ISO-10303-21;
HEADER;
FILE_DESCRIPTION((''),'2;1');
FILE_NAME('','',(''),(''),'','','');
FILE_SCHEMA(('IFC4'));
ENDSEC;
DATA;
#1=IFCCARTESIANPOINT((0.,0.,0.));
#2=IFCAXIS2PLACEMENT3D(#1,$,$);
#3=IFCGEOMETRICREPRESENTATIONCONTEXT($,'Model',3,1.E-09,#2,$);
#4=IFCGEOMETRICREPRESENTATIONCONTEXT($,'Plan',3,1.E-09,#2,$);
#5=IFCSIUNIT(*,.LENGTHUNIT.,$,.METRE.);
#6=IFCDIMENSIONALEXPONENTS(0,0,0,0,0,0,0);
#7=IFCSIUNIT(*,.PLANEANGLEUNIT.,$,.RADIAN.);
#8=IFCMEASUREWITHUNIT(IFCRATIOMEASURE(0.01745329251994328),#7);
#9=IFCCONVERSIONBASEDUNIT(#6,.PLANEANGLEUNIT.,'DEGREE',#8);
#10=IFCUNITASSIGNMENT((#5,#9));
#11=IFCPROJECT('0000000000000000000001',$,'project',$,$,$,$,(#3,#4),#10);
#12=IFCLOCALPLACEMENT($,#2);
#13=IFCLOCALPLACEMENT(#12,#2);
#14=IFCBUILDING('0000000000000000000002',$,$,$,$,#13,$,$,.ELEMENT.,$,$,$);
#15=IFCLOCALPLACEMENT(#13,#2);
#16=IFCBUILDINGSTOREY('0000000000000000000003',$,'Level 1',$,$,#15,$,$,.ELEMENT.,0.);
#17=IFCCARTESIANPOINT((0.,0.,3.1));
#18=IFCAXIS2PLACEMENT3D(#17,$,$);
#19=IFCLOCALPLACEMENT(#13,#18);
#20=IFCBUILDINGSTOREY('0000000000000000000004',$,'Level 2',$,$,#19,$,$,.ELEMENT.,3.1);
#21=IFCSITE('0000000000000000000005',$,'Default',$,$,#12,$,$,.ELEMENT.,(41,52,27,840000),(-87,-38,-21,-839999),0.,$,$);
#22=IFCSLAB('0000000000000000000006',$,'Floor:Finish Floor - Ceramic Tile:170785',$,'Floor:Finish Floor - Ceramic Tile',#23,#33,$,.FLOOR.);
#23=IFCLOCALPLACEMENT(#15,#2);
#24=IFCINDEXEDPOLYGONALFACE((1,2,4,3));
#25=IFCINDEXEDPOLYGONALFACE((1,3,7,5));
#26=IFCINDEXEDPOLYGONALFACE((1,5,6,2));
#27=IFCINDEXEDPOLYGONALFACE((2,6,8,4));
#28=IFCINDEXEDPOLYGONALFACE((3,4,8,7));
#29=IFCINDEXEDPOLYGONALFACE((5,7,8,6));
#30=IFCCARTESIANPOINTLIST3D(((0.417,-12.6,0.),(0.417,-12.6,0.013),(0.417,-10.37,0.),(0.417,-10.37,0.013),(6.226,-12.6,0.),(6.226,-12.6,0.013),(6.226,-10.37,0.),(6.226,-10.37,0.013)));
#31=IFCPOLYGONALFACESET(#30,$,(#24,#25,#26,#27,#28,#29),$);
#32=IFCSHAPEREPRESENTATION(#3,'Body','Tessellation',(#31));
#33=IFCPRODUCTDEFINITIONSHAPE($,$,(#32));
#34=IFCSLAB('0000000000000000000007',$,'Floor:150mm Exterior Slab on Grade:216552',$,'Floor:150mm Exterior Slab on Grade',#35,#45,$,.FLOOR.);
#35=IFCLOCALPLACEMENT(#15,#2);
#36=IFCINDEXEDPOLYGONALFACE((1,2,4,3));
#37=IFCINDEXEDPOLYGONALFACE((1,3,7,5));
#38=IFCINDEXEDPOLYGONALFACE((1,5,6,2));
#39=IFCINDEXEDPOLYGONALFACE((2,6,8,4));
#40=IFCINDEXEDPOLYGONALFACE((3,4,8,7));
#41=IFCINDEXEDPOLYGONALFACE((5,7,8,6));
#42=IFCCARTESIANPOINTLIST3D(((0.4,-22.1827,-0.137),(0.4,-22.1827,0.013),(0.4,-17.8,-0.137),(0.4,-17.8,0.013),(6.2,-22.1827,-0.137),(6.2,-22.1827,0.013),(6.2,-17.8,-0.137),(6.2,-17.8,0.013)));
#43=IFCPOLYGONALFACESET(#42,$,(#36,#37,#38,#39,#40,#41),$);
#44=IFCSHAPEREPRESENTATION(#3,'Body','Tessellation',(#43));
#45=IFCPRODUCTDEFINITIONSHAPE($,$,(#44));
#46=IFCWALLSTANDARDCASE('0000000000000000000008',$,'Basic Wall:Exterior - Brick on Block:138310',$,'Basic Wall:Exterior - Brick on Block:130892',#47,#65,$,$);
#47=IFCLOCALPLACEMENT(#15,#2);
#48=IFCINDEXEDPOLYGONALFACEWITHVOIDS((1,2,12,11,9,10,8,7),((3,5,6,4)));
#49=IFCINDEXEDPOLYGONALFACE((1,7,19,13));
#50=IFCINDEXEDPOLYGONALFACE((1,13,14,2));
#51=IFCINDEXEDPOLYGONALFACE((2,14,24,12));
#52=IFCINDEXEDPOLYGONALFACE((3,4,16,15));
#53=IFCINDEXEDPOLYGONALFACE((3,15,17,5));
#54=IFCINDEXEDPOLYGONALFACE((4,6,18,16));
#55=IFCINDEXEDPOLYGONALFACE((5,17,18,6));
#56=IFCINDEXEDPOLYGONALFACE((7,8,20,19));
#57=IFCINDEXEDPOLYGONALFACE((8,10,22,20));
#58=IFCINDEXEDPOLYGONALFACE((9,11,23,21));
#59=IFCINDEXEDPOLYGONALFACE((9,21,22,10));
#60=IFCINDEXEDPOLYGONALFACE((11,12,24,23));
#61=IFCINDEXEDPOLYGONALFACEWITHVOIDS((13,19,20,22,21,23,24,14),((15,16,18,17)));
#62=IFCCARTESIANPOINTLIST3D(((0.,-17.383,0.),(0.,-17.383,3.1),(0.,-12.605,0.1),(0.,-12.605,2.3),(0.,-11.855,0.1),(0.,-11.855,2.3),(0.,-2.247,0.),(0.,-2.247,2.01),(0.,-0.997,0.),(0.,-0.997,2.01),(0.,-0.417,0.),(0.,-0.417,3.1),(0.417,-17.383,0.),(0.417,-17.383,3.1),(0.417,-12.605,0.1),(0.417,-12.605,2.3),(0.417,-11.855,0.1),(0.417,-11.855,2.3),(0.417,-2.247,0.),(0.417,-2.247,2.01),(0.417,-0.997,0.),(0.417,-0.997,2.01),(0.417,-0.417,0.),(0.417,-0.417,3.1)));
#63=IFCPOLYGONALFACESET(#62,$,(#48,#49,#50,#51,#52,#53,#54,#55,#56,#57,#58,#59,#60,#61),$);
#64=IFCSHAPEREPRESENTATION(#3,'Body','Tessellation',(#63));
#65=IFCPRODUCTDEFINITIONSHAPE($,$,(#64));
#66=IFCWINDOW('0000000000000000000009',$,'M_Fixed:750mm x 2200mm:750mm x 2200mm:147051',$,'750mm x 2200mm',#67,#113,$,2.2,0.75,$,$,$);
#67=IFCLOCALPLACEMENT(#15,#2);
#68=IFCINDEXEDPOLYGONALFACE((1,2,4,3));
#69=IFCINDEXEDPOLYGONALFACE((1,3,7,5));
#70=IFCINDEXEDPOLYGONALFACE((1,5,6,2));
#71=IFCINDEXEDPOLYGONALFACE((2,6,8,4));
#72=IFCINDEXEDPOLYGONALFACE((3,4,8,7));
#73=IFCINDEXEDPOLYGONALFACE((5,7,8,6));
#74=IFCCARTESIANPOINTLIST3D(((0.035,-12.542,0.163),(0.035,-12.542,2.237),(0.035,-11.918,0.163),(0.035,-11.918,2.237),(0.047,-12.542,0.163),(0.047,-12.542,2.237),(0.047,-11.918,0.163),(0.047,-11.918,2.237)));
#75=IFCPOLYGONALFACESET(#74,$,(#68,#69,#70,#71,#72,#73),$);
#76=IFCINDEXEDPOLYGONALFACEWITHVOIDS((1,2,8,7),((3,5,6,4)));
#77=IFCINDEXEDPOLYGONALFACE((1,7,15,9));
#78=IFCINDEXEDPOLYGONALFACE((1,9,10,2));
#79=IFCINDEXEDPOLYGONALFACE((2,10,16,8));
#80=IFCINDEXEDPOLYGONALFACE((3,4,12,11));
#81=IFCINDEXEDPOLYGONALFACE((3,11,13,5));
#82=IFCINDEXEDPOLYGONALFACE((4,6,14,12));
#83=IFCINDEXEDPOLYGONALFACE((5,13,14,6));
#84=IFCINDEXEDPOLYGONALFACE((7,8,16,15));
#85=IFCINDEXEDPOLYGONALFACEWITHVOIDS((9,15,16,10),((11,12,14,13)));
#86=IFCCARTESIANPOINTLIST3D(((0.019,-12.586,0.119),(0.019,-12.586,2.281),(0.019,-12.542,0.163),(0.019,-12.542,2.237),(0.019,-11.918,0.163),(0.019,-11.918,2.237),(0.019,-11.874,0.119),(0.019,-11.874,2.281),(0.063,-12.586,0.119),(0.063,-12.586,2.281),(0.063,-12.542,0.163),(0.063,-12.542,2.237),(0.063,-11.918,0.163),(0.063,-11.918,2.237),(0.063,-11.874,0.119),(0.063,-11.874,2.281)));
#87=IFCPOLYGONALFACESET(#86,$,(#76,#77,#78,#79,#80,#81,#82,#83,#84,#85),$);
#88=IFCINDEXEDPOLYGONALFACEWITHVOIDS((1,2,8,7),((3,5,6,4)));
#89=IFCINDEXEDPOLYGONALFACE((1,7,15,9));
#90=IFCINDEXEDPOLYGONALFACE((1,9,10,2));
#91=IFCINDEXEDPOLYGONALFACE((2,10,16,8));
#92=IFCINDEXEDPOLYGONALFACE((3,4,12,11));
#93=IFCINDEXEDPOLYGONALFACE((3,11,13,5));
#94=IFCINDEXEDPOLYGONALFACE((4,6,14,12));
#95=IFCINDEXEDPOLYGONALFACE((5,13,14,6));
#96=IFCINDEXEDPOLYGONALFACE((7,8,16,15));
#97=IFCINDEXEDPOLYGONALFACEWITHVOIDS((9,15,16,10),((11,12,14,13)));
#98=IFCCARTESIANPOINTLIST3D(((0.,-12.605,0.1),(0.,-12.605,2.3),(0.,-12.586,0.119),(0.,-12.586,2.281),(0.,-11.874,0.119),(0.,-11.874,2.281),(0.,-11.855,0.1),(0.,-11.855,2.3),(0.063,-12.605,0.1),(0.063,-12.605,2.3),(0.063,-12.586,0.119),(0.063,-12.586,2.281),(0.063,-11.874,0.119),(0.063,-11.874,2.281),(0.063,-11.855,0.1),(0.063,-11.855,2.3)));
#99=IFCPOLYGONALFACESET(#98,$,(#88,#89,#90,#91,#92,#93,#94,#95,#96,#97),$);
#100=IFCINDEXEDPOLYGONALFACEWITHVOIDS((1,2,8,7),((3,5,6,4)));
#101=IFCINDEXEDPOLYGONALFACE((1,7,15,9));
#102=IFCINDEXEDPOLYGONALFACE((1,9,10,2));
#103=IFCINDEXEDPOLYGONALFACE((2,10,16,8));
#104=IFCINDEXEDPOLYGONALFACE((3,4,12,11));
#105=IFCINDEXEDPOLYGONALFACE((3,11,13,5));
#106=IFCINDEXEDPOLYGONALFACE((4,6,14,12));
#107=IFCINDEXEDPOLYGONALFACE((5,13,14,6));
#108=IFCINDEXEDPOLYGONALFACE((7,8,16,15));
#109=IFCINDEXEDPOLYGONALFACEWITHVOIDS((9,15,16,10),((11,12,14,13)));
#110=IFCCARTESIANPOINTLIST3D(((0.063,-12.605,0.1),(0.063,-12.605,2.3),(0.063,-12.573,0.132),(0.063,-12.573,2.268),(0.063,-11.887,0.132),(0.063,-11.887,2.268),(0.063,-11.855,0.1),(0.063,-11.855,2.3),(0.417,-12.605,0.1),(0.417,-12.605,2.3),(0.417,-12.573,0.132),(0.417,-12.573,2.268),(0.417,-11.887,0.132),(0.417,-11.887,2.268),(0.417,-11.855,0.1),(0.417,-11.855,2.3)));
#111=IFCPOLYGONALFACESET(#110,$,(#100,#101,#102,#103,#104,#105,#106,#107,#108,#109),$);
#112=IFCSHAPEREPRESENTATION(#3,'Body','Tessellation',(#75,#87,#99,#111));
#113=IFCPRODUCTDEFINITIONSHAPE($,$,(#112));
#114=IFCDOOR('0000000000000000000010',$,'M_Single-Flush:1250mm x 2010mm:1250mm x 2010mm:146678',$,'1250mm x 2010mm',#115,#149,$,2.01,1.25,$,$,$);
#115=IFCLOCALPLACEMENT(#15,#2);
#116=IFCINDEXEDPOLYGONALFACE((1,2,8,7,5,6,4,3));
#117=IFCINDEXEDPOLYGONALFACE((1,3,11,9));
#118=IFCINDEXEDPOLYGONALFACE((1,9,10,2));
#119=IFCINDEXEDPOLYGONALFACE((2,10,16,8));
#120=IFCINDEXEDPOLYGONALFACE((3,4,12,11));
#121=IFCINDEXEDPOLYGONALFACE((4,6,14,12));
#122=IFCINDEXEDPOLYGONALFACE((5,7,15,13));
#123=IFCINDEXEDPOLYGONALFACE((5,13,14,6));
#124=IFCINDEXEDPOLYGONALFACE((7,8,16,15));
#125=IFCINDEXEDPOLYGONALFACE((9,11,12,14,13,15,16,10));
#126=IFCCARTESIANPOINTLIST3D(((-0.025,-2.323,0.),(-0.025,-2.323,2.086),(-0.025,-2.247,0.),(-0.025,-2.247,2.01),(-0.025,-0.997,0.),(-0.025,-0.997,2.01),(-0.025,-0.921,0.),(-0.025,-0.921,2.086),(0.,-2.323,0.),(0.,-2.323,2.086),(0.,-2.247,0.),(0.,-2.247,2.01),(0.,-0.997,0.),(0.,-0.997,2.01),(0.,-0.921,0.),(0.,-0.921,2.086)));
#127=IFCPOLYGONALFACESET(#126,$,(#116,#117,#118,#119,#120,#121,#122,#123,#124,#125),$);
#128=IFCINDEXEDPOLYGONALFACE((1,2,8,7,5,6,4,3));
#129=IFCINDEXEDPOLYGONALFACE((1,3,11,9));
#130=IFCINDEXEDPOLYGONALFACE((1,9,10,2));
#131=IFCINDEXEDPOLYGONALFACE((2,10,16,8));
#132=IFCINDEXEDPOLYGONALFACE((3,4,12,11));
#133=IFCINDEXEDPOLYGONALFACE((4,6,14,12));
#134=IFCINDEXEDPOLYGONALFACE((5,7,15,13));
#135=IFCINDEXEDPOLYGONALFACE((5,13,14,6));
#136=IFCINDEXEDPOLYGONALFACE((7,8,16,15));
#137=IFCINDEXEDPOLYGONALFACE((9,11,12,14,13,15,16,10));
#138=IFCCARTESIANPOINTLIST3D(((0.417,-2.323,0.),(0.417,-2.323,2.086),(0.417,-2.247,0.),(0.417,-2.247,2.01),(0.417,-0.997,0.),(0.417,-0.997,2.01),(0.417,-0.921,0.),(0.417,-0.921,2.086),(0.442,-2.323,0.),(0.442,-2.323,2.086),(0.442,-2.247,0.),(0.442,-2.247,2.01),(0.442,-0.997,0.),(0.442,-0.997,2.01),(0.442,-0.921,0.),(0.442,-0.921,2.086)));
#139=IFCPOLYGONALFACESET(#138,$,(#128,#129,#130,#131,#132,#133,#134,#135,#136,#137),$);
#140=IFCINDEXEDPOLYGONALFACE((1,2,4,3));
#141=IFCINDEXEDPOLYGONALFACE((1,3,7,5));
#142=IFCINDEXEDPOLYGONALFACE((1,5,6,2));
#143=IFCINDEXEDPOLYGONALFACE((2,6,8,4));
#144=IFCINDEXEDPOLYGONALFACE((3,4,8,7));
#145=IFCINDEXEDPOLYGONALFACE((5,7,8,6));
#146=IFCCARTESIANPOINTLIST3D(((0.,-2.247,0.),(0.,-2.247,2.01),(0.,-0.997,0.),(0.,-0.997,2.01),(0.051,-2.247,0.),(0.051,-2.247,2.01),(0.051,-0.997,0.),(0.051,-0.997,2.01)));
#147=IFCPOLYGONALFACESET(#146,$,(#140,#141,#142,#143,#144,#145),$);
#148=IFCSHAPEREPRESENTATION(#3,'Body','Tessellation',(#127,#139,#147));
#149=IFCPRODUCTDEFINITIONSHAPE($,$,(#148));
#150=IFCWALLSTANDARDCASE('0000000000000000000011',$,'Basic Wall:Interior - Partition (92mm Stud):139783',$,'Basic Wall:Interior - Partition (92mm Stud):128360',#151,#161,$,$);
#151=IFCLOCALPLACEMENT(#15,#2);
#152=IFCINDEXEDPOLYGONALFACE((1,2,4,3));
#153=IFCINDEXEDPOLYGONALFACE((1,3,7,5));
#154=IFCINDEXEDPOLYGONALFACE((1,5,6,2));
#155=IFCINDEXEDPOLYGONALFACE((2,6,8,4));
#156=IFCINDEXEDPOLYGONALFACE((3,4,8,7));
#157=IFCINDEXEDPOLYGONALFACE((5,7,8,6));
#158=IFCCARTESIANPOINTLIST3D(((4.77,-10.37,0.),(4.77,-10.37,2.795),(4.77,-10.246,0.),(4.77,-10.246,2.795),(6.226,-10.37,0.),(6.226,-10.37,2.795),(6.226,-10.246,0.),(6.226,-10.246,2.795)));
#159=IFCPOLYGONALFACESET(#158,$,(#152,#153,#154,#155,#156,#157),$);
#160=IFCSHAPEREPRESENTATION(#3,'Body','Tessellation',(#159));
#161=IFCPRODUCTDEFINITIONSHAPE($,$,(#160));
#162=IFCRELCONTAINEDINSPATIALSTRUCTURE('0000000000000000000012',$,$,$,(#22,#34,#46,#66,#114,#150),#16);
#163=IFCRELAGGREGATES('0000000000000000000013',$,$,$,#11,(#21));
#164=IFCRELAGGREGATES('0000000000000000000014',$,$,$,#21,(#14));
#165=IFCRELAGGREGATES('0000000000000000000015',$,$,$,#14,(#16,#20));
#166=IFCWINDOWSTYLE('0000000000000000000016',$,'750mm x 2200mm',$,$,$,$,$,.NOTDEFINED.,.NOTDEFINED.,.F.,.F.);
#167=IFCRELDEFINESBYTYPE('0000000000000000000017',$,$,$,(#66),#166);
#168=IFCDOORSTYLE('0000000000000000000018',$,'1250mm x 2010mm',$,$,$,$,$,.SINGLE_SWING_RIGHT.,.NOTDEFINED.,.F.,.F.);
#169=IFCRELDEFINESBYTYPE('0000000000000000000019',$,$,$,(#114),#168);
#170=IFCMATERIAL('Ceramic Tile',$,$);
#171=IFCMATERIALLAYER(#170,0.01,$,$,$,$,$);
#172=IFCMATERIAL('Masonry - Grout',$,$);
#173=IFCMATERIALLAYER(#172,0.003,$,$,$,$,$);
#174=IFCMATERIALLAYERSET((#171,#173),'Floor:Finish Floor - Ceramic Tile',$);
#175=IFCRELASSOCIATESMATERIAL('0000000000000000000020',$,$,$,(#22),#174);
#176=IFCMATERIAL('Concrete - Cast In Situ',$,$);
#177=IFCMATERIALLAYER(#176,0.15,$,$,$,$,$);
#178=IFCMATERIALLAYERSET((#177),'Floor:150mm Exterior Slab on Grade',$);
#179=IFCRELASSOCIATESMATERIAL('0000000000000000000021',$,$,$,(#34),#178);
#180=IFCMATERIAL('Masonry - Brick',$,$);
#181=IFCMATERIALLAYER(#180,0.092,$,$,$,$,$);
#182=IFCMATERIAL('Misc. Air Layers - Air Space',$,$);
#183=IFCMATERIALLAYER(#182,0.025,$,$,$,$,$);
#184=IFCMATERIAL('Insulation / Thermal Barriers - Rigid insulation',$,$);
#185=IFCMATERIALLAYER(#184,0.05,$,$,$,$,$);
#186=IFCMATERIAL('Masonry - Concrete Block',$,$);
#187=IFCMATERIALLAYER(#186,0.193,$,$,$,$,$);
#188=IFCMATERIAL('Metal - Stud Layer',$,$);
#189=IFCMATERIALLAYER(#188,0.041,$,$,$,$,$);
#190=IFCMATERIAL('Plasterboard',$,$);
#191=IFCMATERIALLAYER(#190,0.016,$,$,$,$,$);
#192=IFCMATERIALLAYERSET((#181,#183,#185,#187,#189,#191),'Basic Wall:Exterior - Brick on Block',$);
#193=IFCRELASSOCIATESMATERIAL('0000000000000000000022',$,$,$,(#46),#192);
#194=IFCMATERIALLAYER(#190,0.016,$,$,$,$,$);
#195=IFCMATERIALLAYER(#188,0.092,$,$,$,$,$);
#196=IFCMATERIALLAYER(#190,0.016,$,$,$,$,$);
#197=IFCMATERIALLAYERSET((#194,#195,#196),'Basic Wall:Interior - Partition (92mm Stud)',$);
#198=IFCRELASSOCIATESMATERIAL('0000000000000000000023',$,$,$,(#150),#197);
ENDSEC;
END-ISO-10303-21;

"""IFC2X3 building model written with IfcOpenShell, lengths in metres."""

from ifc_helpers import new_model, entity, si_unit, converted_unit, frame, frame_2d, origin, origin_2d_with_axis, place, context, project, spatial, polyline, rectangle, outline, extrude, source, transform, mapped, material, layer, layer_set, layer_usage, type_object, type_shapes, element, fill, save


model = new_model("IFC2X3")

# Units and contexts
model_context = context("Model", 3, precision=1e-09, world=origin())
plan_context = context("Plan", 3, precision=1e-09, world=origin())
ifc_project = project(units=[si_unit("LENGTHUNIT", "METRE"), converted_unit("PLANEANGLEUNIT", "DEGREE", entity("IfcRatioMeasure", 0.01745329251994328), si_unit("PLANEANGLEUNIT", "RADIAN"), dimensions=[0, 0, 0, 0, 0, 0, 0])], contexts=[model_context, plan_context])

# Site, building, storey
site_placement = place(None, origin())
site = spatial("IfcSite", under=ifc_project, at=site_placement, Name="Default", CompositionType="ELEMENT", RefLatitude=(41, 52, 27, 840000), RefLongitude=(-87, -38, -21, -839999), RefElevation=0.0)
building_placement = place(site_placement, origin())
building = spatial("IfcBuilding", under=site, at=building_placement, CompositionType="ELEMENT")
storey_1_placement = place(building_placement, origin())
storey_1 = spatial("IfcBuildingStorey", under=building, at=storey_1_placement, Name="Level 1", CompositionType="ELEMENT", Elevation=0.0)

# Slabs
ifc_material_1 = material(Name="Ceramic Tile")
ifc_layer_1 = layer(ifc_material_1, 0.01)
ifc_material_2 = material(Name="Masonry - Grout")
ifc_layer_2 = layer(ifc_material_2, 0.003)
ifc_layer_set_1 = layer_set([ifc_layer_1, ifc_layer_2], Name="Floor:Finish Floor - Ceramic Tile")
ifc_layer_usage_1 = layer_usage(ifc_layer_set_1, "AXIS3", "POSITIVE", 0.0)
slab_1_placement = place(storey_1_placement, frame((0.417, -12.6, 0.0)))
element("IfcSlab", 1, at=slab_1_placement, inside=storey_1, material=ifc_layer_usage_1, Name="Floor:Finish Floor - Ceramic Tile:170785", ObjectType="Floor:Finish Floor - Ceramic Tile", PredefinedType="FLOOR", context=model_context, shape_type="SweptSolid", body=[
    extrude(rectangle(XDim=5.809, YDim=2.23, at=frame_2d((0.0, 0.0), x_axis=(-1.0, 0.0))), frame((2.9045, 1.115, 0.013), z_axis=(0.0, 0.0, -1.0), x_axis=(-1.0, 0.0, 0.0)), (0.0, 0.0, 1.0), 0.013),
])
ifc_material_3 = material(Name="Concrete - Cast In Situ")
ifc_layer_3 = layer(ifc_material_3, 0.15)
ifc_layer_set_2 = layer_set([ifc_layer_3], Name="Floor:150mm Exterior Slab on Grade")
ifc_layer_usage_2 = layer_usage(ifc_layer_set_2, "AXIS3", "POSITIVE", 0.0)
slab_2_placement = place(storey_1_placement, frame((0.4, -22.1827, -0.137)))
element("IfcSlab", 2, at=slab_2_placement, inside=storey_1, material=ifc_layer_usage_2, Name="Floor:150mm Exterior Slab on Grade:216552", ObjectType="Floor:150mm Exterior Slab on Grade", PredefinedType="FLOOR", context=model_context, shape_type="SweptSolid", body=[
    extrude(rectangle(XDim=5.8, YDim=4.3827, at=origin_2d_with_axis()), frame((2.9, 2.1914, 0.15), z_axis=(0.0, 0.0, -1.0), x_axis=(-1.0, 0.0, 0.0)), (0.0, 0.0, 1.0), 0.15),
])

# Wall, openings, window, door
ifc_material_4 = material(Name="Masonry - Brick")
ifc_layer_4 = layer(ifc_material_4, 0.092)
ifc_material_5 = material(Name="Misc. Air Layers - Air Space")
ifc_layer_5 = layer(ifc_material_5, 0.025)
ifc_material_6 = material(Name="Insulation / Thermal Barriers - Rigid insulation")
ifc_layer_6 = layer(ifc_material_6, 0.05)
ifc_material_7 = material(Name="Masonry - Concrete Block")
ifc_layer_7 = layer(ifc_material_7, 0.193)
ifc_material_8 = material(Name="Metal - Stud Layer")
ifc_layer_8 = layer(ifc_material_8, 0.041)
ifc_material_9 = material(Name="Plasterboard")
ifc_layer_9 = layer(ifc_material_9, 0.016)
ifc_layer_set_3 = layer_set([ifc_layer_4, ifc_layer_5, ifc_layer_6, ifc_layer_7, ifc_layer_8, ifc_layer_9], Name="Basic Wall:Exterior - Brick on Block")
ifc_layer_usage_3 = layer_usage(ifc_layer_set_3, "AXIS2", "NEGATIVE", 0.2085)
wall_1_placement = place(storey_1_placement, frame((0.2085, -17.383, 0.0), z_axis=(0.0, 0.0, 1.0), x_axis=(0.0, 1.0, 0.0)))
wall_1 = element("IfcWallStandardCase", 3, at=wall_1_placement, inside=storey_1, material=ifc_layer_usage_3, Name="Basic Wall:Exterior - Brick on Block:138310", ObjectType="Basic Wall:Exterior - Brick on Block:130892", context=model_context, shape_type="SweptSolid", body=[
    extrude(rectangle(XDim=16.966, YDim=0.417, at=frame_2d((8.483, 0.0), x_axis=(-1.0, 0.0))), origin(), (0.0, 0.0, 1.0), 3.1),
])
opening_1_placement = place(wall_1_placement, frame((15.136, -0.2085, 0.0)))
opening_1 = element("IfcOpeningElement", 4, at=opening_1_placement, cuts=wall_1, ObjectType="Opening", context=model_context, shape_type="SweptSolid", body=[
    extrude(rectangle(XDim=1.25, YDim=2.01, at=frame_2d((1.005, 0.625), x_axis=(0.0, 1.0))), frame((0.0, 0.0, 0.0), z_axis=(0.0, 1.0, 0.0), x_axis=(0.0, 0.0, 1.0)), (0.0, 0.0, 1.0), 0.417),
])
opening_2_placement = place(wall_1_placement, frame((4.778, -0.2085, 0.1)))
opening_2 = element("IfcOpeningElement", 5, at=opening_2_placement, cuts=wall_1, ObjectType="Opening", context=model_context, shape_type="SweptSolid", body=[
    extrude(rectangle(XDim=2.2, YDim=0.75, at=frame_2d((1.1, 0.375), x_axis=(1.0, 0.0))), frame((0.0, 0.0, 0.0), z_axis=(0.0, 1.0, 0.0), x_axis=(0.0, 0.0, 1.0)), (0.0, 0.0, 1.0), 0.417),
])
window_style_1 = type_object("IfcWindowStyle", Name="750mm x 2200mm", ConstructionType="NOTDEFINED", OperationType="NOTDEFINED", ParameterTakesPrecedence=False, Sizeable=False)
shared_shape_1 = source(origin(), model_context, "Body", "SweptSolid", [
    extrude(rectangle(XDim=0.012, YDim=0.624, at=origin_2d_with_axis()), frame((0.375, 0.376, 0.063), z_axis=(0.0, 0.0, 1.0), x_axis=(0.0, -1.0, 0.0)), (0.0, 0.0, 1.0), 2.074),
    extrude(outline(polyline([(-0.356, -1.081), (0.356, -1.081), (0.356, 1.081), (-0.356, 1.081), (-0.356, -1.081)]), holes=[polyline([(-0.312, -1.037), (-0.312, 1.037), (0.312, 1.037), (0.312, -1.037), (-0.312, -1.037)])]), frame((0.375, 0.354, 1.1), z_axis=(0.0, 1.0, 0.0), x_axis=(1.0, 0.0, 0.0)), (0.0, 0.0, 1.0), 0.044),
    extrude(outline(polyline([(-0.375, -1.1), (0.375, -1.1), (0.375, 1.1), (-0.375, 1.1), (-0.375, -1.1)]), holes=[polyline([(-0.356, -1.081), (-0.356, 1.081), (0.356, 1.081), (0.356, -1.081), (-0.356, -1.081)])]), frame((0.375, 0.354, 1.1), z_axis=(0.0, 1.0, 0.0), x_axis=(1.0, 0.0, 0.0)), (0.0, 0.0, 1.0), 0.063),
    extrude(outline(polyline([(-0.375, -1.1), (0.375, -1.1), (0.375, 1.1), (-0.375, 1.1), (-0.375, -1.1)]), holes=[polyline([(-0.343, -1.068), (-0.343, 1.068), (0.343, 1.068), (0.343, -1.068), (-0.343, -1.068)])]), frame((0.375, 0.0, 1.1), z_axis=(0.0, 1.0, 0.0), x_axis=(1.0, 0.0, 0.0)), (0.0, 0.0, 1.0), 0.354),
])
type_shapes(window_style_1, [shared_shape_1])
window_1_placement = place(opening_2_placement, origin())
window_1 = element("IfcWindow", 6, at=window_1_placement, inside=storey_1, type_object=window_style_1, Name="M_Fixed:750mm x 2200mm:750mm x 2200mm:147051", ObjectType="750mm x 2200mm", OverallHeight=2.2, OverallWidth=0.75, context=model_context, shape_type="MappedRepresentation", body=[
    mapped(shared_shape_1, transform((0.0, 0.0, 0.0), scale=1.0)),
])
fill(opening_2, window_1)
door_style_1 = type_object("IfcDoorStyle", Name="1250mm x 2010mm", ConstructionType="NOTDEFINED", OperationType="SINGLE_SWING_RIGHT", ParameterTakesPrecedence=False, Sizeable=False)
shared_shape_2 = source(origin(), model_context, "Body", "SweptSolid", [
    extrude(outline(polyline([(-0.701, -1.062), (0.701, -1.062), (0.701, 1.024), (0.625, 1.024), (0.625, -0.986), (-0.625, -0.986), (-0.625, 1.024), (-0.701, 1.024), (-0.701, -1.062)])), frame((0.625, 0.417, 1.024), z_axis=(0.0, 1.0, 0.0), x_axis=(1.0, 0.0, 0.0)), (0.0, 0.0, 1.0), 0.025),
    extrude(outline(polyline([(-1.062, -0.701), (1.024, -0.701), (1.024, -0.625), (-0.986, -0.625), (-0.986, 0.625), (1.024, 0.625), (1.024, 0.701), (-1.062, 0.701), (-1.062, -0.701)])), frame((0.625, -0.025, 1.024), z_axis=(0.0, 1.0, 0.0), x_axis=(0.0, 0.0, -1.0)), (0.0, 0.0, 1.0), 0.025),
    extrude(rectangle(XDim=0.051, YDim=1.25, at=origin_2d_with_axis()), frame((0.625, 0.3915, 0.0), z_axis=(0.0, 0.0, 1.0), x_axis=(0.0, 1.0, 0.0)), (0.0, 0.0, 1.0), 2.01),
])
type_shapes(door_style_1, [shared_shape_2])
door_1_placement = place(opening_1_placement, origin())
door_1 = element("IfcDoor", 7, at=door_1_placement, inside=storey_1, type_object=door_style_1, Name="M_Single-Flush:1250mm x 2010mm:1250mm x 2010mm:146678", ObjectType="1250mm x 2010mm", OverallHeight=2.01, OverallWidth=1.25, context=model_context, shape_type="MappedRepresentation", body=[
    mapped(shared_shape_2, transform((0.0, 0.0, 0.0), scale=1.0)),
])
fill(opening_1, door_1)

# Wall
ifc_layer_10 = layer(ifc_material_9, 0.016)
ifc_layer_11 = layer(ifc_material_8, 0.092)
ifc_layer_12 = layer(ifc_material_9, 0.016)
ifc_layer_set_4 = layer_set([ifc_layer_10, ifc_layer_11, ifc_layer_12], Name="Basic Wall:Interior - Partition (92mm Stud)")
ifc_layer_usage_4 = layer_usage(ifc_layer_set_4, "AXIS2", "NEGATIVE", 0.062)
wall_2_placement = place(storey_1_placement, frame((4.77, -10.308, 0.0)))
element("IfcWallStandardCase", 8, at=wall_2_placement, inside=storey_1, material=ifc_layer_usage_4, Name="Basic Wall:Interior - Partition (92mm Stud):139783", ObjectType="Basic Wall:Interior - Partition (92mm Stud):128360", context=model_context, shape_type="SweptSolid", body=[
    extrude(rectangle(XDim=1.456, YDim=0.124, at=frame_2d((0.728, 0.0), x_axis=(-1.0, 0.0))), origin(), (0.0, 0.0, 1.0), 2.795),
])

# Shared definitions
storey_2_placement = place(building_placement, frame((0.0, 0.0, 3.1)))
storey_2 = spatial("IfcBuildingStorey", under=building, at=storey_2_placement, Name="Level 2", CompositionType="ELEMENT", Elevation=3.1)

save(model, "model.ifc")
